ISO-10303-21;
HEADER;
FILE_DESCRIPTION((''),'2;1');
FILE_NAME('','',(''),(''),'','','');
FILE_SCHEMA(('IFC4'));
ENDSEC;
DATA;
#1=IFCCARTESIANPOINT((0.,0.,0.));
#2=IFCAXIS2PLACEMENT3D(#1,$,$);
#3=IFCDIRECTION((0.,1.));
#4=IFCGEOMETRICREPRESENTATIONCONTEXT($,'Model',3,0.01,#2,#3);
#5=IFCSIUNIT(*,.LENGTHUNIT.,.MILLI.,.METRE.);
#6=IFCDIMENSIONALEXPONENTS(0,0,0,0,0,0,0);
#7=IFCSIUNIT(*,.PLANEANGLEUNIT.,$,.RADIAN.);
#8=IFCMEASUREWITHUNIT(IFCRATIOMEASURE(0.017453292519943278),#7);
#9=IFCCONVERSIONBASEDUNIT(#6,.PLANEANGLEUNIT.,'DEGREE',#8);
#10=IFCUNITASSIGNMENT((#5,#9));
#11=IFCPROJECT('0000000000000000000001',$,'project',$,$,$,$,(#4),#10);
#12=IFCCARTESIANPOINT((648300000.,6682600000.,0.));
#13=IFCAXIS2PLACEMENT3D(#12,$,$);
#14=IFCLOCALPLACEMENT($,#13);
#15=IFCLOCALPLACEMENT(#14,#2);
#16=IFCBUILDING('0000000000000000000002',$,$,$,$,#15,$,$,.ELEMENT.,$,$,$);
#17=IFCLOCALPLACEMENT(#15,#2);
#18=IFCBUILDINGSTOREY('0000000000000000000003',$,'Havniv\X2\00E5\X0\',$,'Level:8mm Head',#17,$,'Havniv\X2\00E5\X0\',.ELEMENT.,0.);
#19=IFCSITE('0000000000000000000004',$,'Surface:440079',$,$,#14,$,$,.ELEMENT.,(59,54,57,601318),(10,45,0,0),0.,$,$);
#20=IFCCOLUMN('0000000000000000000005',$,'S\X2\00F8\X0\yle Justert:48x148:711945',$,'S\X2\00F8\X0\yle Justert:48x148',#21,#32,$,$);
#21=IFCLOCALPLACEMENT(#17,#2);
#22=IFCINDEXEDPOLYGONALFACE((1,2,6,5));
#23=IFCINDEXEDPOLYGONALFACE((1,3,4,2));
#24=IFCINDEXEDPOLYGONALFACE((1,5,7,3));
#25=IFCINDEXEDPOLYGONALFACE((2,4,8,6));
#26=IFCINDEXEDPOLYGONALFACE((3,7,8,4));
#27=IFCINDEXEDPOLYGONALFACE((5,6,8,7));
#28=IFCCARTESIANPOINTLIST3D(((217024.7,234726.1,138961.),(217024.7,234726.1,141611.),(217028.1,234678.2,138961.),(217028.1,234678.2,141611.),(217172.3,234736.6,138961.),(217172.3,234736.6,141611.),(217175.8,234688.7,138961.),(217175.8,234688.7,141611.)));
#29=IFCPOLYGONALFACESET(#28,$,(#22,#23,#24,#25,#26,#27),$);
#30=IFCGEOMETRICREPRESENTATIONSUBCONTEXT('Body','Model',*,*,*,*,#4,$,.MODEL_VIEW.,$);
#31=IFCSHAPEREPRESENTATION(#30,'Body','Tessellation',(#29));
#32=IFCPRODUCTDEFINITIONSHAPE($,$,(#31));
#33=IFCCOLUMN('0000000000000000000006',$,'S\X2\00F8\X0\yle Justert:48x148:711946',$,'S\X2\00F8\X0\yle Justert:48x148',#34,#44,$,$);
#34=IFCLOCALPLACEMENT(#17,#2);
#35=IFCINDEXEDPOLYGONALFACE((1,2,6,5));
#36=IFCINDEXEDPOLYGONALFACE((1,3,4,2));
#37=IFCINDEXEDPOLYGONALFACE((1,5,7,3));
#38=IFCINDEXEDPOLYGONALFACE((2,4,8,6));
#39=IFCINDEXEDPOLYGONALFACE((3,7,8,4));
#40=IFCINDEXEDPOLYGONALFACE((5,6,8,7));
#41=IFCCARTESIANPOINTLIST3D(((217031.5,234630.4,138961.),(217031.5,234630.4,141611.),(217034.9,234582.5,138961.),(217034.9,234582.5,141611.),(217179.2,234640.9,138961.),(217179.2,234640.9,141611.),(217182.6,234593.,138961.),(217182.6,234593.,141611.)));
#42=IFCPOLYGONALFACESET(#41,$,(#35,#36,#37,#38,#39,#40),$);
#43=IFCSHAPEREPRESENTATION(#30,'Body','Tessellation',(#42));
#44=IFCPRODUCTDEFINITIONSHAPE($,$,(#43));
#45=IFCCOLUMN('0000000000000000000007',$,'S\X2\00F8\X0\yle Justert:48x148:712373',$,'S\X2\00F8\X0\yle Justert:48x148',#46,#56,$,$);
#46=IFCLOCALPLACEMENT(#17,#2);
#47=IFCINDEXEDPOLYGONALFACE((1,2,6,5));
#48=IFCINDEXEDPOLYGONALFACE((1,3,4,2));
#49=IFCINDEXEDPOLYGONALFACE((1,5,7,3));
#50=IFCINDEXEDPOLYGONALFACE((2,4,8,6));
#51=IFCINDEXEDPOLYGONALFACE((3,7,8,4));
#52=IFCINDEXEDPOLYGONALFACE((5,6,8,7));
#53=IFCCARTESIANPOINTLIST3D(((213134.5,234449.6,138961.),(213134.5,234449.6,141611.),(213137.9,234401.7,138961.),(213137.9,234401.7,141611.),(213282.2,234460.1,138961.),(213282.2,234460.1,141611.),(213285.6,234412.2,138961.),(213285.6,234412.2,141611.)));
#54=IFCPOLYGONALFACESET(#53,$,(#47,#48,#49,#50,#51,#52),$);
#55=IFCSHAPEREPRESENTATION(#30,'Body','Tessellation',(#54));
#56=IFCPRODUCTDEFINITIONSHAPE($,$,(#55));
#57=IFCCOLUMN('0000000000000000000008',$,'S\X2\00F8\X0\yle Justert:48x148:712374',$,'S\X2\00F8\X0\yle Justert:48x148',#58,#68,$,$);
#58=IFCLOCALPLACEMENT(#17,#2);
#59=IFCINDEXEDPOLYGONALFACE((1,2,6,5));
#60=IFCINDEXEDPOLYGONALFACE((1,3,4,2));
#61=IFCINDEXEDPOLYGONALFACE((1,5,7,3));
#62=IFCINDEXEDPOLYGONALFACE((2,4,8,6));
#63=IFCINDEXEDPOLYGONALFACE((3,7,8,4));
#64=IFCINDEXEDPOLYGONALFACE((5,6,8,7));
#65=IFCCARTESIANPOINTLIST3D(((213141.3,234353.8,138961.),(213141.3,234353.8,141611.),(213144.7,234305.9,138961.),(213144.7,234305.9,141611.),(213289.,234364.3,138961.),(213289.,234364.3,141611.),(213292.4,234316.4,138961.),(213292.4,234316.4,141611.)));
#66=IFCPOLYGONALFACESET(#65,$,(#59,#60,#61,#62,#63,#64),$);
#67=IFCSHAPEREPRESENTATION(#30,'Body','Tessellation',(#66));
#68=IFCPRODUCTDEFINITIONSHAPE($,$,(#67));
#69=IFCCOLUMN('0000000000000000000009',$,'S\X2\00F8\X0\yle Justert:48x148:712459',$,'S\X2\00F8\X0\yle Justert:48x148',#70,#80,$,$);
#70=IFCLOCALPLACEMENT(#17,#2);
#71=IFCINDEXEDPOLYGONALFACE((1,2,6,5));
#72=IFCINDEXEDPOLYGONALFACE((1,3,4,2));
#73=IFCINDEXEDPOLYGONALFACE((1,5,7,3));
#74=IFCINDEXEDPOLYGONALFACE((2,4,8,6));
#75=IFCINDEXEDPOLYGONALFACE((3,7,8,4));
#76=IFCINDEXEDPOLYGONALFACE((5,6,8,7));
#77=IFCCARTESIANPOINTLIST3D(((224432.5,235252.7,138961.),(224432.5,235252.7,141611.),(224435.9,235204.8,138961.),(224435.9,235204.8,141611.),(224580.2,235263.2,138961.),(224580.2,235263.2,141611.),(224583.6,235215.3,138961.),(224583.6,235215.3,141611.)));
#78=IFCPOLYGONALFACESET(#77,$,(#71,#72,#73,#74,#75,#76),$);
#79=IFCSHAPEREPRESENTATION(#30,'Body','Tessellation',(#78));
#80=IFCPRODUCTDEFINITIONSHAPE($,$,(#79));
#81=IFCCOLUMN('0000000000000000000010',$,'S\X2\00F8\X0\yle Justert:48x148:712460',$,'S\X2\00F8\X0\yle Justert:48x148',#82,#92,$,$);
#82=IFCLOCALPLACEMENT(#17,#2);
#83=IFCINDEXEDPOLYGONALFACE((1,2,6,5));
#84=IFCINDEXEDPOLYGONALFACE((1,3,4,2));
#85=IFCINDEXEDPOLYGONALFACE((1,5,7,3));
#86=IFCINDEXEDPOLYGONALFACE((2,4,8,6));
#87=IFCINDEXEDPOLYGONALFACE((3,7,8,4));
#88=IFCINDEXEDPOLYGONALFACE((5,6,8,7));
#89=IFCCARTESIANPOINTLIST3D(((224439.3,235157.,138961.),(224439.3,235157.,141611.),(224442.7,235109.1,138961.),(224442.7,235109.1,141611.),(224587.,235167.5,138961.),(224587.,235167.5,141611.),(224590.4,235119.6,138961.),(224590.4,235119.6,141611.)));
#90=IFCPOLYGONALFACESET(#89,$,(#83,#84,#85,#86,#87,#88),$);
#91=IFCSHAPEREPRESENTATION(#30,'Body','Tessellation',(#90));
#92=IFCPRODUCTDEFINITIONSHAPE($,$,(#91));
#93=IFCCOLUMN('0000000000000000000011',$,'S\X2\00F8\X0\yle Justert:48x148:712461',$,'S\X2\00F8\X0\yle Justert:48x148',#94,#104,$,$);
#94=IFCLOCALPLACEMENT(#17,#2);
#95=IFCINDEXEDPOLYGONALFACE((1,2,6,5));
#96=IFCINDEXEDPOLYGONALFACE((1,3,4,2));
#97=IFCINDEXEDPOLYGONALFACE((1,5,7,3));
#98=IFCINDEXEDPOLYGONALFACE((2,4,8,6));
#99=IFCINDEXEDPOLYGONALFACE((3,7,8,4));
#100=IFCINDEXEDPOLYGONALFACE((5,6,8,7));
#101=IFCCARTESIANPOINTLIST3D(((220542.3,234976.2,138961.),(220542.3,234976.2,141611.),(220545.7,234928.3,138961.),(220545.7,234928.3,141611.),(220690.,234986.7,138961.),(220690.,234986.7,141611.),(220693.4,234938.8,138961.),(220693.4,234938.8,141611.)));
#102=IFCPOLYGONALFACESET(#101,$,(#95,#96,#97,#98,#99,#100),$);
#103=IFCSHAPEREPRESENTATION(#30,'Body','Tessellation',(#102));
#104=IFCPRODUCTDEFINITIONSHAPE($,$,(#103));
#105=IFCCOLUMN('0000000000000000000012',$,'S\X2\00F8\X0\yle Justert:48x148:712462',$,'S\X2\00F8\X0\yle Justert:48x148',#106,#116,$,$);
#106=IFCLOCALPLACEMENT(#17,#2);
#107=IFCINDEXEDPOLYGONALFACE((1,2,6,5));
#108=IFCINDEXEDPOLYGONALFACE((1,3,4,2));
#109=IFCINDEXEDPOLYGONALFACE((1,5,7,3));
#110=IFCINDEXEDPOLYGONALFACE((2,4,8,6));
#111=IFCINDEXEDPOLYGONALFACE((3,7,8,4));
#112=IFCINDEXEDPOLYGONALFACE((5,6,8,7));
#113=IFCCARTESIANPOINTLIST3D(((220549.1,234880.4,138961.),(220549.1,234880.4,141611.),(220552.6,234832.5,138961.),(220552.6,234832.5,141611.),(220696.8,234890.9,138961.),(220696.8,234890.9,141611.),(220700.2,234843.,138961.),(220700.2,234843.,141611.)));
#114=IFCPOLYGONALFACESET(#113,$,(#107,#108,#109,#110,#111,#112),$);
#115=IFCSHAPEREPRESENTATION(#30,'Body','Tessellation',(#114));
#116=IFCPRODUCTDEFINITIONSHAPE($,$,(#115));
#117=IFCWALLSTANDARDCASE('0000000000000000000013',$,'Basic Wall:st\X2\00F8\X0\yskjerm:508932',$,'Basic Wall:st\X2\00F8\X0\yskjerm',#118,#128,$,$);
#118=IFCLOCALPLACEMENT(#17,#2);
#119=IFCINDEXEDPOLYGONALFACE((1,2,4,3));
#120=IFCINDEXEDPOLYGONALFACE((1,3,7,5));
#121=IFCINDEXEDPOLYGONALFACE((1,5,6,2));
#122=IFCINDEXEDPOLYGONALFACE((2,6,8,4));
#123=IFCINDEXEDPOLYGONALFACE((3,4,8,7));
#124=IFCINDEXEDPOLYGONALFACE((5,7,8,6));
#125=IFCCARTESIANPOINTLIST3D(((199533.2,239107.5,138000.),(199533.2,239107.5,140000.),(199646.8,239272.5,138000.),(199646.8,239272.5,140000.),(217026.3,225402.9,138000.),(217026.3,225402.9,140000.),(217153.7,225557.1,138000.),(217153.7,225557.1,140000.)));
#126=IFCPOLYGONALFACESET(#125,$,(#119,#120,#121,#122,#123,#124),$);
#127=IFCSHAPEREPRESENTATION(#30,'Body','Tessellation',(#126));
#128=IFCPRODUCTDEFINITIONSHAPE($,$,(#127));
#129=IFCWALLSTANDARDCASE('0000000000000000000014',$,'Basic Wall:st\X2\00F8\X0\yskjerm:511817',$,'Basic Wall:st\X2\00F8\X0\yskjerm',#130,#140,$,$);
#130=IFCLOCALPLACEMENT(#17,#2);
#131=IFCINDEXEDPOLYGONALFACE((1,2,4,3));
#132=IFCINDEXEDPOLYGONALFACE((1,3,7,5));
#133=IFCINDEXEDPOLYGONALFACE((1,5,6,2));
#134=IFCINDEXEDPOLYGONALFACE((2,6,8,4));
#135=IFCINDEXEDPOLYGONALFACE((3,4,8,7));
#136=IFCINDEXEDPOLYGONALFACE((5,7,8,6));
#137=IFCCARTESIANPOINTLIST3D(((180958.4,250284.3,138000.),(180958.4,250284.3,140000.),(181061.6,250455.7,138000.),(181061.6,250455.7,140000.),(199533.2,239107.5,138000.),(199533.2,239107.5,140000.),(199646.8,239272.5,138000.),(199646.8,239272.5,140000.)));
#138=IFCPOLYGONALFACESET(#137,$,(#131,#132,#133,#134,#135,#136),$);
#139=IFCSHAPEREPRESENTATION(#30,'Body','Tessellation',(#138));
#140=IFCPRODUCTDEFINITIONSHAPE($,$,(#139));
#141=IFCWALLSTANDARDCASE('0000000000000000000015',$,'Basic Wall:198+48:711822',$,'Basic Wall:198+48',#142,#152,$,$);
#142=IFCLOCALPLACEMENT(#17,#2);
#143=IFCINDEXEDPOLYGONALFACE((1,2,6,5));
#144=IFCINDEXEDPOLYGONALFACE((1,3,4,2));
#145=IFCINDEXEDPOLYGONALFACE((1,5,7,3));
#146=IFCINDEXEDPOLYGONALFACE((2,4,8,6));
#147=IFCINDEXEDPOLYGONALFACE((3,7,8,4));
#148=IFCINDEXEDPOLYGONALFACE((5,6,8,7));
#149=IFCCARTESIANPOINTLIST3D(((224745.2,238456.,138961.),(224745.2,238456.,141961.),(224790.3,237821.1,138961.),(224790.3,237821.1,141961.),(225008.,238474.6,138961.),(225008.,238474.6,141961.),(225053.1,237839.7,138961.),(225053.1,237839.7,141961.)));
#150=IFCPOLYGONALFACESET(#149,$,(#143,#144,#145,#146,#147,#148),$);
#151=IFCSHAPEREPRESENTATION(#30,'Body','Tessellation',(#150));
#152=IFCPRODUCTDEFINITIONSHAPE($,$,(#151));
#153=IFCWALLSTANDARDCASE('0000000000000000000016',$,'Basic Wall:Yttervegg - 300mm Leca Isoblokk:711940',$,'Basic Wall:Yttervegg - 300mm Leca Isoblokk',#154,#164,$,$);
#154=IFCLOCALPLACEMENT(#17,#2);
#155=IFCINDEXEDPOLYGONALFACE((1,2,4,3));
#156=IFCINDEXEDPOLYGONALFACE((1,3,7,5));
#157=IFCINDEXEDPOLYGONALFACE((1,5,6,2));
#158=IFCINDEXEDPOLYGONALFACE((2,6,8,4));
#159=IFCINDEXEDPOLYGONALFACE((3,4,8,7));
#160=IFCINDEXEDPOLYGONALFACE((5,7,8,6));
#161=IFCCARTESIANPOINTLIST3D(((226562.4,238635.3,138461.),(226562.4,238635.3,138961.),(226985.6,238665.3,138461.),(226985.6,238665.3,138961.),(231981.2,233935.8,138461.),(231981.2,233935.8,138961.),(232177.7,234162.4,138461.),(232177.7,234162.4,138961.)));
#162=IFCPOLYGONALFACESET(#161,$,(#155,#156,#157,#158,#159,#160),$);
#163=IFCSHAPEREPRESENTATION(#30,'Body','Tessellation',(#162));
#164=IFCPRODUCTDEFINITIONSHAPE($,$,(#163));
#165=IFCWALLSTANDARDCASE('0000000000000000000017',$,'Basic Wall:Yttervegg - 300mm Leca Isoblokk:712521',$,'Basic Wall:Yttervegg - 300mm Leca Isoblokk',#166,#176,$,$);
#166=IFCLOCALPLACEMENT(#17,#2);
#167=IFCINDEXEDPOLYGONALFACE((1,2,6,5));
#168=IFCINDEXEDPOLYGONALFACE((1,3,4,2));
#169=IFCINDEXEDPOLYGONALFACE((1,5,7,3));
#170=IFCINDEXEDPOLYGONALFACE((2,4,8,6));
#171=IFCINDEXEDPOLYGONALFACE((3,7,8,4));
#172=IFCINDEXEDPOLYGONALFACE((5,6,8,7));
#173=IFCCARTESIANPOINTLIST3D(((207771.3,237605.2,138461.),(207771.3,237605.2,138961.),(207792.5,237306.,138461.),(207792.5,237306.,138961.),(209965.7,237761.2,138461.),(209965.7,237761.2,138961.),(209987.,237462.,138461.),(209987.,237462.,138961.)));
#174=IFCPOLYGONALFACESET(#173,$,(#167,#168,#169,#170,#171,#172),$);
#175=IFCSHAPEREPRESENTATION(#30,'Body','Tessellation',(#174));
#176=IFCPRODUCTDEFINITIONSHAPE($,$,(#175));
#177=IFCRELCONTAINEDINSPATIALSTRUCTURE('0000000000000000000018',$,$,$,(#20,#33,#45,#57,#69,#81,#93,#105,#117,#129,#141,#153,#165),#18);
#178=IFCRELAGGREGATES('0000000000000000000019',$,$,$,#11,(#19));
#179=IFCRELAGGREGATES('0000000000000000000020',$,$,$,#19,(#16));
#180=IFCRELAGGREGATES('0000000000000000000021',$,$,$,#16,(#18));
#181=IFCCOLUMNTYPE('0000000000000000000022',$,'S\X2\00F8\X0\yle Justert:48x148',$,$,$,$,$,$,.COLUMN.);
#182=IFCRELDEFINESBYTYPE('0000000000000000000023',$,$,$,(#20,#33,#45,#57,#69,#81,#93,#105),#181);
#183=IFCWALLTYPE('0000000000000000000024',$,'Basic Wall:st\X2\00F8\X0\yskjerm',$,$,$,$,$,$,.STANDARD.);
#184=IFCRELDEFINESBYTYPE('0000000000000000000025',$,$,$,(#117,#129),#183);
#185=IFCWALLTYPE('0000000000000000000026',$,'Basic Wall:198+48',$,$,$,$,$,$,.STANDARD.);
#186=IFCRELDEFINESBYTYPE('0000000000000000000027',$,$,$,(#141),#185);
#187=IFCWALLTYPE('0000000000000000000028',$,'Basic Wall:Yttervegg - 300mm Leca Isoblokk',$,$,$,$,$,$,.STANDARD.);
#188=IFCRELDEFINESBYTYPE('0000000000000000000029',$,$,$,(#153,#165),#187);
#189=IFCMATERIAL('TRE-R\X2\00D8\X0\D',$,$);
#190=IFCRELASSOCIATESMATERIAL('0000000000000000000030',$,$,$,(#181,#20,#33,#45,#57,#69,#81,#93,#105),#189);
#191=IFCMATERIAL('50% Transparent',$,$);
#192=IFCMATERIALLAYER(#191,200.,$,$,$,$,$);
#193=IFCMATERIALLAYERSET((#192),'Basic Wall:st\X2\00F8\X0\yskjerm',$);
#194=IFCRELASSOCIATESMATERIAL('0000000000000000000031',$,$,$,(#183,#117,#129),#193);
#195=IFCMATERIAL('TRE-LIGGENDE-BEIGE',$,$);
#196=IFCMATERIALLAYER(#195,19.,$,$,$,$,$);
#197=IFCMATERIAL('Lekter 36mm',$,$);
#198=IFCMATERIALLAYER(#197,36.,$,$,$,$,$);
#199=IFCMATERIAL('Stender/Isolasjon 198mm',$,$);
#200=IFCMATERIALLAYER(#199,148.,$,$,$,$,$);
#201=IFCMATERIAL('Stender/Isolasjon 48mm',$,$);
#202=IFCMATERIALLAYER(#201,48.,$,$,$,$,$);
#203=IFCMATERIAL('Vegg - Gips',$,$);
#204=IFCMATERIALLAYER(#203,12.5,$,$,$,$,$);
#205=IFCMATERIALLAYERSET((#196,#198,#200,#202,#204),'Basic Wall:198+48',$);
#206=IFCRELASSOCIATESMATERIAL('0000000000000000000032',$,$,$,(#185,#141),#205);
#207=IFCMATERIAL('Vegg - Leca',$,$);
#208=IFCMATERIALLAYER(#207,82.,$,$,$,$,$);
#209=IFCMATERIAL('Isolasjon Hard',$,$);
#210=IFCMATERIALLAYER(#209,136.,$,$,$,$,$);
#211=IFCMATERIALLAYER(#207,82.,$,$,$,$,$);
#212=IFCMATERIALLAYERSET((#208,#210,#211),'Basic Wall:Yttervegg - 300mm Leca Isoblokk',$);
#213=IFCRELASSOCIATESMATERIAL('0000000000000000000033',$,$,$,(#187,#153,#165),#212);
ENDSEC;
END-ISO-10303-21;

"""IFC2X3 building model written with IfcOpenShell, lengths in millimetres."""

from ifc_helpers import new_model, entity, si_unit, converted_unit, direction, frame, frame_2d, origin, origin_2d_with_axis, place, context, subcontext, project, spatial, polyline, rectangle, outline, extrude, source, transform, mapped, material, layer, layer_set, layer_usage, type_object, type_shapes, element, save


model = new_model("IFC2X3")

# Units and contexts
model_context = context("Model", 3, precision=0.01, world=origin(), true_north=direction((0.0, 1.0)))
body_context = subcontext(model_context, "Body", "Model", "MODEL_VIEW")
ifc_project = project(units=[si_unit("LENGTHUNIT", "METRE", prefix="MILLI"), converted_unit("PLANEANGLEUNIT", "DEGREE", entity("IfcRatioMeasure", 0.017453292519943278), si_unit("PLANEANGLEUNIT", "RADIAN"), dimensions=[0, 0, 0, 0, 0, 0, 0])], contexts=[model_context])

# Site, building, storey
site_placement = place(None, frame((648300000.0, 6682600000.0, 0.0)))
site = spatial("IfcSite", under=ifc_project, at=site_placement, Name="Surface:440079", CompositionType="ELEMENT", RefLatitude=(59, 54, 57, 601318), RefLongitude=(10, 45, 0, 0), RefElevation=0.0)
building_placement = place(site_placement, origin())
building = spatial("IfcBuilding", under=site, at=building_placement, CompositionType="ELEMENT")
storey_placement = place(building_placement, origin())
storey = spatial("IfcBuildingStorey", under=building, at=storey_placement, Name="Havnivå", ObjectType="Level:8mm Head", LongName="Havnivå", CompositionType="ELEMENT", Elevation=0.0)

# Columns
ifc_material_1 = material(Name="TRE-RØD")
column_type = type_object("IfcColumnType", Name="Søyle Justert:48x148", PredefinedType="COLUMN", material=ifc_material_1)
shared_shape_1 = source(origin(), body_context, "Body", "SweptSolid", [
    extrude(rectangle(XDim=48.0, YDim=148.0, at=origin_2d_with_axis()), frame((0.0, 0.0, 138961.0), z_axis=(0.0, 0.0, 1.0), x_axis=(0.0, -1.0, 0.0)), (0.0, 0.0, 1.0), 2650.0),
])
type_shapes(column_type, [shared_shape_1])
for number, where, z_axis, x_axis, name in (
    (1, (217100.2, 234707.4, 0.0), (0.0, 0.0, 1.0), (0.997483, 0.070908, 0.0), "Søyle Justert:48x148:711945"),
    (2, (217107.0, 234611.7, 0.0), (0.0, 0.0, 1.0), (0.997483, 0.070908, 0.0), "Søyle Justert:48x148:711946"),
    (3, (213210.1, 234430.9, 0.0), (0.0, 0.0, 1.0), (0.997483, 0.070908, 0.0), "Søyle Justert:48x148:712373"),
    (4, (213216.9, 234335.1, 0.0), (0.0, 0.0, 1.0), (0.997483, 0.070908, 0.0), "Søyle Justert:48x148:712374"),
    (5, (224508.0, 235234.0, 0.0), (0.0, 0.0, 1.0), (0.997483, 0.070908, 0.0), "Søyle Justert:48x148:712459"),
    (6, (224514.8, 235138.3, 0.0), (0.0, 0.0, 1.0), (0.997483, 0.070908, 0.0), "Søyle Justert:48x148:712460"),
    (7, (220617.9, 234957.5, 0.0), (0.0, 0.0, 1.0), (0.997483, 0.070908, 0.0), "Søyle Justert:48x148:712461"),
    (8, (220624.7, 234861.7, 0.0), (0.0, 0.0, 1.0), (0.997483, 0.070908, 0.0), "Søyle Justert:48x148:712462"),
):
    element("IfcColumn", number, at=place(storey_placement, frame(where, z_axis=z_axis, x_axis=x_axis)), inside=storey, type_object=column_type, material=ifc_material_1, Name=name, ObjectType="Søyle Justert:48x148", context=body_context, shape_type="MappedRepresentation", body=[
        mapped(shared_shape_1, transform((0.0, 0.0, 0.0), scale=1.0)),
    ])

# Walls
ifc_material_2 = material(Name="50% Transparent")
ifc_layer_1 = layer(ifc_material_2, 200.0)
ifc_layer_set_1 = layer_set([ifc_layer_1], Name="Basic Wall:støyskjerm")
ifc_layer_usage_1 = layer_usage(ifc_layer_set_1, "AXIS2", "NEGATIVE", 100.0)
wall_type_1 = type_object("IfcWallType", Name="Basic Wall:støyskjerm", PredefinedType="STANDARD", material=ifc_layer_set_1)
wall_1_placement = place(storey_placement, frame((199585.2, 239193.8, 138000.0), z_axis=(0.0, 0.0, 1.0), x_axis=(0.787192, -0.616708, 0.0)))
element("IfcWallStandardCase", 9, at=wall_1_placement, inside=storey, type_object=wall_type_1, material=ifc_layer_usage_1, Name="Basic Wall:støyskjerm:508932", ObjectType="Basic Wall:støyskjerm", context=body_context, shape_type="SweptSolid", body=[
    extrude(outline(polyline([(22234.5, -100.0), (22239.7, 100.0), (0.0, 100.0), (12.3, -100.0), (22234.5, -100.0)])), origin(), (0.0, 0.0, 1.0), 2000.0),
])
ifc_layer_usage_2 = layer_usage(ifc_layer_set_1, "AXIS2", "NEGATIVE", 100.0)
wall_2_placement = place(storey_placement, frame((199595.3, 239186.8, 138000.0), z_axis=(0.0, 0.0, 1.0), x_axis=(-0.856841, 0.51558, 0.0)))
element("IfcWallStandardCase", 10, at=wall_2_placement, inside=storey, type_object=wall_type_1, material=ifc_layer_usage_2, Name="Basic Wall:støyskjerm:511817", ObjectType="Basic Wall:støyskjerm", context=body_context, shape_type="SweptSolid", body=[
    extrude(outline(polyline([(21690.4, -100.0), (21690.4, 100.0), (12.3, 100.0), (0.0, -100.0), (21690.4, -100.0)])), origin(), (0.0, 0.0, 1.0), 2000.0),
])
ifc_material_3 = material(Name="TRE-LIGGENDE-BEIGE")
ifc_layer_2 = layer(ifc_material_3, 19.0)
ifc_material_4 = material(Name="Lekter 36mm")
ifc_layer_3 = layer(ifc_material_4, 36.0)
ifc_material_5 = material(Name="Stender/Isolasjon 198mm")
ifc_layer_4 = layer(ifc_material_5, 148.0)
ifc_material_6 = material(Name="Stender/Isolasjon 48mm")
ifc_layer_5 = layer(ifc_material_6, 48.0)
ifc_material_7 = material(Name="Vegg - Gips")
ifc_layer_6 = layer(ifc_material_7, 12.5)
ifc_layer_set_2 = layer_set([ifc_layer_2, ifc_layer_3, ifc_layer_4, ifc_layer_5, ifc_layer_6], Name="Basic Wall:198+48")
ifc_layer_usage_3 = layer_usage(ifc_layer_set_2, "AXIS2", "NEGATIVE", 131.8)
wall_type_2 = type_object("IfcWallType", Name="Basic Wall:198+48", PredefinedType="STANDARD", material=ifc_layer_set_2)
wall_3_placement = place(storey_placement, frame((224876.6, 238465.3, 138961.0), z_axis=(0.0, 0.0, 1.0), x_axis=(0.070908, -0.997483, 0.0)))
element("IfcWallStandardCase", 11, at=wall_3_placement, inside=storey, type_object=wall_type_2, material=ifc_layer_usage_3, Name="Basic Wall:198+48:711822", ObjectType="Basic Wall:198+48", context=body_context, shape_type="SweptSolid", body=[
    extrude(rectangle(XDim=636.5, YDim=263.5, at=frame_2d((318.2, 0.0), x_axis=(-1.0, 0.0))), origin(), (0.0, 0.0, 1.0), 3000.0),
])

# Shared definitions
ifc_material_8 = material(Name="Vegg - Leca")
ifc_layer_7 = layer(ifc_material_8, 82.0)
ifc_material_9 = material(Name="Isolasjon Hard")
ifc_layer_8 = layer(ifc_material_9, 136.0)
ifc_layer_9 = layer(ifc_material_8, 82.0)
ifc_layer_set_3 = layer_set([ifc_layer_7, ifc_layer_8, ifc_layer_9], Name="Basic Wall:Yttervegg - 300mm Leca Isoblokk")
wall_type_3 = type_object("IfcWallType", Name="Basic Wall:Yttervegg - 300mm Leca Isoblokk", PredefinedType="STANDARD", material=ifc_layer_set_3)

# Walls
ifc_layer_usage_4 = layer_usage(ifc_layer_set_3, "AXIS2", "POSITIVE", -150.0)
wall_4_placement = place(storey_placement, frame((226660.7, 238748.6, 138461.0), z_axis=(0.0, 0.0, 1.0), x_axis=(0.755467, -0.655187, 0.0)))
element("IfcWallStandardCase", 12, at=wall_4_placement, inside=storey, type_object=wall_type_3, material=ifc_layer_usage_4, Name="Basic Wall:Yttervegg - 300mm Leca Isoblokk:711940", ObjectType="Basic Wall:Yttervegg - 300mm Leca Isoblokk", context=body_context, shape_type="SweptSolid", body=[
    extrude(outline(polyline([(7172.7, -150.0), (7172.7, 150.0), (300.0, 150.0), (0.0, -150.0), (7172.7, -150.0)])), origin(), (0.0, 0.0, 1.0), 500.0),
])
ifc_layer_usage_5 = layer_usage(ifc_layer_set_3, "AXIS2", "POSITIVE", -150.0)
wall_5_placement = place(storey_placement, frame((207781.9, 237455.6, 138461.0), z_axis=(0.0, 0.0, 1.0), x_axis=(0.997483, 0.070908, 0.0)))
element("IfcWallStandardCase", 13, at=wall_5_placement, inside=storey, type_object=wall_type_3, material=ifc_layer_usage_5, Name="Basic Wall:Yttervegg - 300mm Leca Isoblokk:712521", ObjectType="Basic Wall:Yttervegg - 300mm Leca Isoblokk", context=body_context, shape_type="SweptSolid", body=[
    extrude(rectangle(XDim=2200.0, YDim=300.0, at=frame_2d((1100.0, 0.0), x_axis=(-1.0, 0.0))), origin(), (0.0, 0.0, 1.0), 500.0),
])

save(model, "model.ifc")
